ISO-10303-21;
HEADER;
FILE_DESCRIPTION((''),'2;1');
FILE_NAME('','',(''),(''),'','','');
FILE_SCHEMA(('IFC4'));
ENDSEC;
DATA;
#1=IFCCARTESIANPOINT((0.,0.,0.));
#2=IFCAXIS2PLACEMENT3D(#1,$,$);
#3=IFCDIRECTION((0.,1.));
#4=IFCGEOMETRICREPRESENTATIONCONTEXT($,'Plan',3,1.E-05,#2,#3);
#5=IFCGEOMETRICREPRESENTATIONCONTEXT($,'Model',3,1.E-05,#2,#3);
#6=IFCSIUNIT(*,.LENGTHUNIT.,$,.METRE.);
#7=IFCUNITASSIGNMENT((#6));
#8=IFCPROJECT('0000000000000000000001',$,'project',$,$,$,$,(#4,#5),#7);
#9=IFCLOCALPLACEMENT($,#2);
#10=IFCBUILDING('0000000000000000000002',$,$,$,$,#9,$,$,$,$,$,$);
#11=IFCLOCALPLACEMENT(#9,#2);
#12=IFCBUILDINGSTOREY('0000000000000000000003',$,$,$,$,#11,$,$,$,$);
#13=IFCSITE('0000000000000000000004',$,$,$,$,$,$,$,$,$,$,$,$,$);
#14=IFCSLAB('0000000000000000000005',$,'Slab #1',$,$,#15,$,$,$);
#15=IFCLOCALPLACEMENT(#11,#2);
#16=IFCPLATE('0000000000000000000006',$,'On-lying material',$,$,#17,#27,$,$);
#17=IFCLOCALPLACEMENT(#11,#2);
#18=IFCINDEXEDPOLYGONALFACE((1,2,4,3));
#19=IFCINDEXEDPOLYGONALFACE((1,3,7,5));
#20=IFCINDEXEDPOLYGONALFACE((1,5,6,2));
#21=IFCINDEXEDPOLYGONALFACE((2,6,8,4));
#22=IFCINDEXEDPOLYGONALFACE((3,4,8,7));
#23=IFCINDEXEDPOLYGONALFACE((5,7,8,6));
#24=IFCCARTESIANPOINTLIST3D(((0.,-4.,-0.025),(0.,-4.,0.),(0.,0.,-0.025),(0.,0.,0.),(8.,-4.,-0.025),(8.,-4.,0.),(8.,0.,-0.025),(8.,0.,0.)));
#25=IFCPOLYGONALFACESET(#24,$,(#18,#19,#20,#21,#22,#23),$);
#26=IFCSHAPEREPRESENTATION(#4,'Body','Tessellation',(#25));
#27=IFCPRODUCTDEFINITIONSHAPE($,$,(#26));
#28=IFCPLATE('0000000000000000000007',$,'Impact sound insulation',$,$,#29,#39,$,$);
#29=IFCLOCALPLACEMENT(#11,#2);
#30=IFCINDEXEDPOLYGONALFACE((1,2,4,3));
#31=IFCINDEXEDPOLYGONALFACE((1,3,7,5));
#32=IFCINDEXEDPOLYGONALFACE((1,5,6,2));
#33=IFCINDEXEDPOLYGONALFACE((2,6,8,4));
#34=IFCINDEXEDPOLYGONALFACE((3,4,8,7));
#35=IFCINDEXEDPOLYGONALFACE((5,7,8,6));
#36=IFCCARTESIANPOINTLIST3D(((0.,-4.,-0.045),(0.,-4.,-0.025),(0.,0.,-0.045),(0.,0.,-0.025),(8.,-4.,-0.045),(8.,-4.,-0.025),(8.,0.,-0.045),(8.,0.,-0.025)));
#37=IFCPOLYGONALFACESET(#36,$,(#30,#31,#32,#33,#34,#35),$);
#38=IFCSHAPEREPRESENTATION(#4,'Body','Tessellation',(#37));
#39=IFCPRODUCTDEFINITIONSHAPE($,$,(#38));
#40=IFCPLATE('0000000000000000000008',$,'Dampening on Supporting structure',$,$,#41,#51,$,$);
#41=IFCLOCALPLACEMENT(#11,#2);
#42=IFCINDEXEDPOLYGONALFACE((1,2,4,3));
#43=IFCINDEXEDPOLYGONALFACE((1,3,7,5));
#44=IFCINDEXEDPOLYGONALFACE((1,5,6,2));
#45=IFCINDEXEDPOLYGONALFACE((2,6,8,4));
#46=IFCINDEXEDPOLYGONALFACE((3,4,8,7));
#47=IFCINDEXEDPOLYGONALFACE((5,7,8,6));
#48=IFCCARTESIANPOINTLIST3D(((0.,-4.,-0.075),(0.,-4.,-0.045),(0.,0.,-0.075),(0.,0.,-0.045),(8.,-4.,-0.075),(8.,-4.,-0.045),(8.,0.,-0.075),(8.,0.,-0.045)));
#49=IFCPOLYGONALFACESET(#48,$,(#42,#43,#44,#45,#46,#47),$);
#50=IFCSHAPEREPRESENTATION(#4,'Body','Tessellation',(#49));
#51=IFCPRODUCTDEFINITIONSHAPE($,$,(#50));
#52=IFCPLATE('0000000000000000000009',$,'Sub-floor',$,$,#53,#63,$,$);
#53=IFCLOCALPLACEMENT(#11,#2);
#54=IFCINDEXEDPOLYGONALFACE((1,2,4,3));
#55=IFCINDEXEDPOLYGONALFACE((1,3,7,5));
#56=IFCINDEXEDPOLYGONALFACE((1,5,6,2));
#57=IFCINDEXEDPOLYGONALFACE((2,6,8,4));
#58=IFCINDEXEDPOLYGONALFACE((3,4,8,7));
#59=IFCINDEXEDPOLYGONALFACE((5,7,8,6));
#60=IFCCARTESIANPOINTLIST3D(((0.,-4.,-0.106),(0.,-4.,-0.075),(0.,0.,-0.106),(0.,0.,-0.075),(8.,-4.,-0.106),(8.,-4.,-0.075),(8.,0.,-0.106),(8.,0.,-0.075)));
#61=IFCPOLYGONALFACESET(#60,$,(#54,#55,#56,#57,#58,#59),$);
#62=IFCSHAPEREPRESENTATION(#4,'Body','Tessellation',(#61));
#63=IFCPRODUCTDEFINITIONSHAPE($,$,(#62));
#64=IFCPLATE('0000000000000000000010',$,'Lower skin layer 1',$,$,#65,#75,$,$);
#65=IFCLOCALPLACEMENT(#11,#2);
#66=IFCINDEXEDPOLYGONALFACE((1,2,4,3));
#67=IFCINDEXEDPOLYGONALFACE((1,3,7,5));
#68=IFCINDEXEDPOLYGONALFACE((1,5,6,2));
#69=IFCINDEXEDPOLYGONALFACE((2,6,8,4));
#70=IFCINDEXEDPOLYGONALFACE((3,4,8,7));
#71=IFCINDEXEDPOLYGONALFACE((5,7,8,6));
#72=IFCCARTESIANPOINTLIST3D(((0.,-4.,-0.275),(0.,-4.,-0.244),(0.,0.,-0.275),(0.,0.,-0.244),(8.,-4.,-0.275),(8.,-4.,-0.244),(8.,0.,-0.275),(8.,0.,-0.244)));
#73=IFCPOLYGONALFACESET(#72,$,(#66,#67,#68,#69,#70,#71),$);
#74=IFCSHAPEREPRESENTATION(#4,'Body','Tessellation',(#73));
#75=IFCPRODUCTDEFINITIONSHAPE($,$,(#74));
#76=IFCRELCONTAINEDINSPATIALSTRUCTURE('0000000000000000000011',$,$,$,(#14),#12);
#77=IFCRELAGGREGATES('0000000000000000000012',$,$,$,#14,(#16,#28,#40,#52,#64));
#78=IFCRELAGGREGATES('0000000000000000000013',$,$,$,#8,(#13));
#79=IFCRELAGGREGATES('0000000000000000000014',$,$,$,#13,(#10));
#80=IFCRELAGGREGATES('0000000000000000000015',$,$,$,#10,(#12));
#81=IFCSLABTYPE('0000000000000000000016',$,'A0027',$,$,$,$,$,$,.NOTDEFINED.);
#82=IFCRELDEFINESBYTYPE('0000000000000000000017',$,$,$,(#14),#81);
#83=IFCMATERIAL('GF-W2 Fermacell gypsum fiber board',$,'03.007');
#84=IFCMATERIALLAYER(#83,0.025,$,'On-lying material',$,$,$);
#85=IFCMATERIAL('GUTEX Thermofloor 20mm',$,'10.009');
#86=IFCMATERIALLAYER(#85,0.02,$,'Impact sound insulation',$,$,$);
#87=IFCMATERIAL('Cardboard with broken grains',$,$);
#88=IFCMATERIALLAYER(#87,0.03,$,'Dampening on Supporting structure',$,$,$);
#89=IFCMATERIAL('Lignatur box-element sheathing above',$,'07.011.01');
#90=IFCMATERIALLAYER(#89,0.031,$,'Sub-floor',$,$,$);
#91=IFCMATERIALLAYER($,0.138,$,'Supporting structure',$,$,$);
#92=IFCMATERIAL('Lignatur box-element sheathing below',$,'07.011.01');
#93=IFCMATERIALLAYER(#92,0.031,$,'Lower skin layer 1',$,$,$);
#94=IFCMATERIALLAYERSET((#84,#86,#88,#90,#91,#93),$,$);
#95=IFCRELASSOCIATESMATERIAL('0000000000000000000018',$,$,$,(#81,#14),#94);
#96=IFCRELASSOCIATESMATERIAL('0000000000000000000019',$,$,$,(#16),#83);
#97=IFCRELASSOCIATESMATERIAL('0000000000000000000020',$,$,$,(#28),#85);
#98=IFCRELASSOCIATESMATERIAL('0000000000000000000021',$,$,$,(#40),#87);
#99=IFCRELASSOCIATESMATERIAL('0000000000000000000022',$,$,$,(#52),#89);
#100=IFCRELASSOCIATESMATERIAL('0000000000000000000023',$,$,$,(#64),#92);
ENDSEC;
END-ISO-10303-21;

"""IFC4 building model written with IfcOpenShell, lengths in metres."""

from ifc_helpers import new_model, si_unit, direction, frame, frame_2d, origin, origin_with_axes, place, context, project, spatial, rectangle, extrude, material, layer, layer_set, type_object, element, aggregate, save


model = new_model("IFC4")

# Units and contexts
plan_context = context("Plan", 3, precision=1e-05, world=origin(), true_north=direction((0.0, 1.0)))
model_context = context("Model", 3, precision=1e-05, world=origin(), true_north=direction((0.0, 1.0)))
ifc_project = project(units=[si_unit("LENGTHUNIT", "METRE")], contexts=[plan_context, model_context])

# Site, building, storey
site = spatial("IfcSite", under=ifc_project)
building_placement = place(None, origin())
building = spatial("IfcBuilding", under=site, at=building_placement)
storey_placement = place(building_placement, origin())
storey = spatial("IfcBuildingStorey", under=building, at=storey_placement)

# Slab, plates
ifc_material_1 = material(Name="GF-W2 Fermacell gypsum fiber board", Category="03.007")
ifc_layer_1 = layer(ifc_material_1, 0.025, Name="On-lying material")
ifc_material_2 = material(Name="GUTEX Thermofloor 20mm", Category="10.009")
ifc_layer_2 = layer(ifc_material_2, 0.02, Name="Impact sound insulation")
ifc_material_3 = material(Name="Cardboard with broken grains")
ifc_layer_3 = layer(ifc_material_3, 0.03, Name="Dampening on Supporting structure")
ifc_material_4 = material(Name="Lignatur box-element sheathing above", Category="07.011.01")
ifc_layer_4 = layer(ifc_material_4, 0.031, Name="Sub-floor")
ifc_layer_5 = layer(None, 0.138, Name="Supporting structure")
ifc_material_5 = material(Name="Lignatur box-element sheathing below", Category="07.011.01")
ifc_layer_6 = layer(ifc_material_5, 0.031, Name="Lower skin layer 1")
ifc_layer_set = layer_set([ifc_layer_1, ifc_layer_2, ifc_layer_3, ifc_layer_4, ifc_layer_5, ifc_layer_6])
slab_type = type_object("IfcSlabType", Name="A0027", PredefinedType="NOTDEFINED", material=ifc_layer_set)
slab_placement = place(None, frame((0.0, 0.0, 0.0), z_axis=(0.0, 0.0, -1.0), x_axis=(1.0, 0.0, 0.0)))
slab = element("IfcSlab", 1, at=slab_placement, inside=storey, type_object=slab_type, material=ifc_layer_set, Name="Slab #1")
plate_1_placement = place(slab_placement, origin())
plate_1 = element("IfcPlate", 2, at=plate_1_placement, material=ifc_material_1, Name="On-lying material", context=plan_context, shape_type="SweptSolid", body=[
    extrude(rectangle(XDim=8.0, YDim=4.0, at=frame_2d((4.0, 2.0), x_axis=(1.0, 0.0))), origin_with_axes(), (0.0, 0.0, 1.0), 0.025),
])
plate_2_placement = place(slab_placement, origin())
plate_2 = element("IfcPlate", 3, at=plate_2_placement, material=ifc_material_2, Name="Impact sound insulation", context=plan_context, shape_type="SweptSolid", body=[
    extrude(rectangle(XDim=8.0, YDim=4.0, at=frame_2d((4.0, 2.0), x_axis=(1.0, 0.0))), frame((0.0, 0.0, 0.025), z_axis=(0.0, 0.0, 1.0), x_axis=(1.0, 0.0, 0.0)), (0.0, 0.0, 1.0), 0.02),
])
plate_3_placement = place(slab_placement, origin())
plate_3 = element("IfcPlate", 4, at=plate_3_placement, material=ifc_material_3, Name="Dampening on Supporting structure", context=plan_context, shape_type="SweptSolid", body=[
    extrude(rectangle(XDim=8.0, YDim=4.0, at=frame_2d((4.0, 2.0), x_axis=(1.0, 0.0))), frame((0.0, 0.0, 0.045), z_axis=(0.0, 0.0, 1.0), x_axis=(1.0, 0.0, 0.0)), (0.0, 0.0, 1.0), 0.03),
])
plate_4_placement = place(slab_placement, origin())
plate_4 = element("IfcPlate", 5, at=plate_4_placement, material=ifc_material_4, Name="Sub-floor", context=plan_context, shape_type="SweptSolid", body=[
    extrude(rectangle(XDim=8.0, YDim=4.0, at=frame_2d((4.0, 2.0), x_axis=(1.0, 0.0))), frame((0.0, 0.0, 0.075), z_axis=(0.0, 0.0, 1.0), x_axis=(1.0, 0.0, 0.0)), (0.0, 0.0, 1.0), 0.031),
])
plate_5_placement = place(slab_placement, origin())
plate_5 = element("IfcPlate", 6, at=plate_5_placement, material=ifc_material_5, Name="Lower skin layer 1", context=plan_context, shape_type="SweptSolid", body=[
    extrude(rectangle(XDim=8.0, YDim=4.0, at=frame_2d((4.0, 2.0), x_axis=(1.0, 0.0))), frame((0.0, 0.0, 0.244), z_axis=(0.0, 0.0, 1.0), x_axis=(1.0, 0.0, 0.0)), (0.0, 0.0, 1.0), 0.031),
])
aggregate(slab, [plate_1, plate_2, plate_3, plate_4, plate_5])

save(model, "model.ifc")
